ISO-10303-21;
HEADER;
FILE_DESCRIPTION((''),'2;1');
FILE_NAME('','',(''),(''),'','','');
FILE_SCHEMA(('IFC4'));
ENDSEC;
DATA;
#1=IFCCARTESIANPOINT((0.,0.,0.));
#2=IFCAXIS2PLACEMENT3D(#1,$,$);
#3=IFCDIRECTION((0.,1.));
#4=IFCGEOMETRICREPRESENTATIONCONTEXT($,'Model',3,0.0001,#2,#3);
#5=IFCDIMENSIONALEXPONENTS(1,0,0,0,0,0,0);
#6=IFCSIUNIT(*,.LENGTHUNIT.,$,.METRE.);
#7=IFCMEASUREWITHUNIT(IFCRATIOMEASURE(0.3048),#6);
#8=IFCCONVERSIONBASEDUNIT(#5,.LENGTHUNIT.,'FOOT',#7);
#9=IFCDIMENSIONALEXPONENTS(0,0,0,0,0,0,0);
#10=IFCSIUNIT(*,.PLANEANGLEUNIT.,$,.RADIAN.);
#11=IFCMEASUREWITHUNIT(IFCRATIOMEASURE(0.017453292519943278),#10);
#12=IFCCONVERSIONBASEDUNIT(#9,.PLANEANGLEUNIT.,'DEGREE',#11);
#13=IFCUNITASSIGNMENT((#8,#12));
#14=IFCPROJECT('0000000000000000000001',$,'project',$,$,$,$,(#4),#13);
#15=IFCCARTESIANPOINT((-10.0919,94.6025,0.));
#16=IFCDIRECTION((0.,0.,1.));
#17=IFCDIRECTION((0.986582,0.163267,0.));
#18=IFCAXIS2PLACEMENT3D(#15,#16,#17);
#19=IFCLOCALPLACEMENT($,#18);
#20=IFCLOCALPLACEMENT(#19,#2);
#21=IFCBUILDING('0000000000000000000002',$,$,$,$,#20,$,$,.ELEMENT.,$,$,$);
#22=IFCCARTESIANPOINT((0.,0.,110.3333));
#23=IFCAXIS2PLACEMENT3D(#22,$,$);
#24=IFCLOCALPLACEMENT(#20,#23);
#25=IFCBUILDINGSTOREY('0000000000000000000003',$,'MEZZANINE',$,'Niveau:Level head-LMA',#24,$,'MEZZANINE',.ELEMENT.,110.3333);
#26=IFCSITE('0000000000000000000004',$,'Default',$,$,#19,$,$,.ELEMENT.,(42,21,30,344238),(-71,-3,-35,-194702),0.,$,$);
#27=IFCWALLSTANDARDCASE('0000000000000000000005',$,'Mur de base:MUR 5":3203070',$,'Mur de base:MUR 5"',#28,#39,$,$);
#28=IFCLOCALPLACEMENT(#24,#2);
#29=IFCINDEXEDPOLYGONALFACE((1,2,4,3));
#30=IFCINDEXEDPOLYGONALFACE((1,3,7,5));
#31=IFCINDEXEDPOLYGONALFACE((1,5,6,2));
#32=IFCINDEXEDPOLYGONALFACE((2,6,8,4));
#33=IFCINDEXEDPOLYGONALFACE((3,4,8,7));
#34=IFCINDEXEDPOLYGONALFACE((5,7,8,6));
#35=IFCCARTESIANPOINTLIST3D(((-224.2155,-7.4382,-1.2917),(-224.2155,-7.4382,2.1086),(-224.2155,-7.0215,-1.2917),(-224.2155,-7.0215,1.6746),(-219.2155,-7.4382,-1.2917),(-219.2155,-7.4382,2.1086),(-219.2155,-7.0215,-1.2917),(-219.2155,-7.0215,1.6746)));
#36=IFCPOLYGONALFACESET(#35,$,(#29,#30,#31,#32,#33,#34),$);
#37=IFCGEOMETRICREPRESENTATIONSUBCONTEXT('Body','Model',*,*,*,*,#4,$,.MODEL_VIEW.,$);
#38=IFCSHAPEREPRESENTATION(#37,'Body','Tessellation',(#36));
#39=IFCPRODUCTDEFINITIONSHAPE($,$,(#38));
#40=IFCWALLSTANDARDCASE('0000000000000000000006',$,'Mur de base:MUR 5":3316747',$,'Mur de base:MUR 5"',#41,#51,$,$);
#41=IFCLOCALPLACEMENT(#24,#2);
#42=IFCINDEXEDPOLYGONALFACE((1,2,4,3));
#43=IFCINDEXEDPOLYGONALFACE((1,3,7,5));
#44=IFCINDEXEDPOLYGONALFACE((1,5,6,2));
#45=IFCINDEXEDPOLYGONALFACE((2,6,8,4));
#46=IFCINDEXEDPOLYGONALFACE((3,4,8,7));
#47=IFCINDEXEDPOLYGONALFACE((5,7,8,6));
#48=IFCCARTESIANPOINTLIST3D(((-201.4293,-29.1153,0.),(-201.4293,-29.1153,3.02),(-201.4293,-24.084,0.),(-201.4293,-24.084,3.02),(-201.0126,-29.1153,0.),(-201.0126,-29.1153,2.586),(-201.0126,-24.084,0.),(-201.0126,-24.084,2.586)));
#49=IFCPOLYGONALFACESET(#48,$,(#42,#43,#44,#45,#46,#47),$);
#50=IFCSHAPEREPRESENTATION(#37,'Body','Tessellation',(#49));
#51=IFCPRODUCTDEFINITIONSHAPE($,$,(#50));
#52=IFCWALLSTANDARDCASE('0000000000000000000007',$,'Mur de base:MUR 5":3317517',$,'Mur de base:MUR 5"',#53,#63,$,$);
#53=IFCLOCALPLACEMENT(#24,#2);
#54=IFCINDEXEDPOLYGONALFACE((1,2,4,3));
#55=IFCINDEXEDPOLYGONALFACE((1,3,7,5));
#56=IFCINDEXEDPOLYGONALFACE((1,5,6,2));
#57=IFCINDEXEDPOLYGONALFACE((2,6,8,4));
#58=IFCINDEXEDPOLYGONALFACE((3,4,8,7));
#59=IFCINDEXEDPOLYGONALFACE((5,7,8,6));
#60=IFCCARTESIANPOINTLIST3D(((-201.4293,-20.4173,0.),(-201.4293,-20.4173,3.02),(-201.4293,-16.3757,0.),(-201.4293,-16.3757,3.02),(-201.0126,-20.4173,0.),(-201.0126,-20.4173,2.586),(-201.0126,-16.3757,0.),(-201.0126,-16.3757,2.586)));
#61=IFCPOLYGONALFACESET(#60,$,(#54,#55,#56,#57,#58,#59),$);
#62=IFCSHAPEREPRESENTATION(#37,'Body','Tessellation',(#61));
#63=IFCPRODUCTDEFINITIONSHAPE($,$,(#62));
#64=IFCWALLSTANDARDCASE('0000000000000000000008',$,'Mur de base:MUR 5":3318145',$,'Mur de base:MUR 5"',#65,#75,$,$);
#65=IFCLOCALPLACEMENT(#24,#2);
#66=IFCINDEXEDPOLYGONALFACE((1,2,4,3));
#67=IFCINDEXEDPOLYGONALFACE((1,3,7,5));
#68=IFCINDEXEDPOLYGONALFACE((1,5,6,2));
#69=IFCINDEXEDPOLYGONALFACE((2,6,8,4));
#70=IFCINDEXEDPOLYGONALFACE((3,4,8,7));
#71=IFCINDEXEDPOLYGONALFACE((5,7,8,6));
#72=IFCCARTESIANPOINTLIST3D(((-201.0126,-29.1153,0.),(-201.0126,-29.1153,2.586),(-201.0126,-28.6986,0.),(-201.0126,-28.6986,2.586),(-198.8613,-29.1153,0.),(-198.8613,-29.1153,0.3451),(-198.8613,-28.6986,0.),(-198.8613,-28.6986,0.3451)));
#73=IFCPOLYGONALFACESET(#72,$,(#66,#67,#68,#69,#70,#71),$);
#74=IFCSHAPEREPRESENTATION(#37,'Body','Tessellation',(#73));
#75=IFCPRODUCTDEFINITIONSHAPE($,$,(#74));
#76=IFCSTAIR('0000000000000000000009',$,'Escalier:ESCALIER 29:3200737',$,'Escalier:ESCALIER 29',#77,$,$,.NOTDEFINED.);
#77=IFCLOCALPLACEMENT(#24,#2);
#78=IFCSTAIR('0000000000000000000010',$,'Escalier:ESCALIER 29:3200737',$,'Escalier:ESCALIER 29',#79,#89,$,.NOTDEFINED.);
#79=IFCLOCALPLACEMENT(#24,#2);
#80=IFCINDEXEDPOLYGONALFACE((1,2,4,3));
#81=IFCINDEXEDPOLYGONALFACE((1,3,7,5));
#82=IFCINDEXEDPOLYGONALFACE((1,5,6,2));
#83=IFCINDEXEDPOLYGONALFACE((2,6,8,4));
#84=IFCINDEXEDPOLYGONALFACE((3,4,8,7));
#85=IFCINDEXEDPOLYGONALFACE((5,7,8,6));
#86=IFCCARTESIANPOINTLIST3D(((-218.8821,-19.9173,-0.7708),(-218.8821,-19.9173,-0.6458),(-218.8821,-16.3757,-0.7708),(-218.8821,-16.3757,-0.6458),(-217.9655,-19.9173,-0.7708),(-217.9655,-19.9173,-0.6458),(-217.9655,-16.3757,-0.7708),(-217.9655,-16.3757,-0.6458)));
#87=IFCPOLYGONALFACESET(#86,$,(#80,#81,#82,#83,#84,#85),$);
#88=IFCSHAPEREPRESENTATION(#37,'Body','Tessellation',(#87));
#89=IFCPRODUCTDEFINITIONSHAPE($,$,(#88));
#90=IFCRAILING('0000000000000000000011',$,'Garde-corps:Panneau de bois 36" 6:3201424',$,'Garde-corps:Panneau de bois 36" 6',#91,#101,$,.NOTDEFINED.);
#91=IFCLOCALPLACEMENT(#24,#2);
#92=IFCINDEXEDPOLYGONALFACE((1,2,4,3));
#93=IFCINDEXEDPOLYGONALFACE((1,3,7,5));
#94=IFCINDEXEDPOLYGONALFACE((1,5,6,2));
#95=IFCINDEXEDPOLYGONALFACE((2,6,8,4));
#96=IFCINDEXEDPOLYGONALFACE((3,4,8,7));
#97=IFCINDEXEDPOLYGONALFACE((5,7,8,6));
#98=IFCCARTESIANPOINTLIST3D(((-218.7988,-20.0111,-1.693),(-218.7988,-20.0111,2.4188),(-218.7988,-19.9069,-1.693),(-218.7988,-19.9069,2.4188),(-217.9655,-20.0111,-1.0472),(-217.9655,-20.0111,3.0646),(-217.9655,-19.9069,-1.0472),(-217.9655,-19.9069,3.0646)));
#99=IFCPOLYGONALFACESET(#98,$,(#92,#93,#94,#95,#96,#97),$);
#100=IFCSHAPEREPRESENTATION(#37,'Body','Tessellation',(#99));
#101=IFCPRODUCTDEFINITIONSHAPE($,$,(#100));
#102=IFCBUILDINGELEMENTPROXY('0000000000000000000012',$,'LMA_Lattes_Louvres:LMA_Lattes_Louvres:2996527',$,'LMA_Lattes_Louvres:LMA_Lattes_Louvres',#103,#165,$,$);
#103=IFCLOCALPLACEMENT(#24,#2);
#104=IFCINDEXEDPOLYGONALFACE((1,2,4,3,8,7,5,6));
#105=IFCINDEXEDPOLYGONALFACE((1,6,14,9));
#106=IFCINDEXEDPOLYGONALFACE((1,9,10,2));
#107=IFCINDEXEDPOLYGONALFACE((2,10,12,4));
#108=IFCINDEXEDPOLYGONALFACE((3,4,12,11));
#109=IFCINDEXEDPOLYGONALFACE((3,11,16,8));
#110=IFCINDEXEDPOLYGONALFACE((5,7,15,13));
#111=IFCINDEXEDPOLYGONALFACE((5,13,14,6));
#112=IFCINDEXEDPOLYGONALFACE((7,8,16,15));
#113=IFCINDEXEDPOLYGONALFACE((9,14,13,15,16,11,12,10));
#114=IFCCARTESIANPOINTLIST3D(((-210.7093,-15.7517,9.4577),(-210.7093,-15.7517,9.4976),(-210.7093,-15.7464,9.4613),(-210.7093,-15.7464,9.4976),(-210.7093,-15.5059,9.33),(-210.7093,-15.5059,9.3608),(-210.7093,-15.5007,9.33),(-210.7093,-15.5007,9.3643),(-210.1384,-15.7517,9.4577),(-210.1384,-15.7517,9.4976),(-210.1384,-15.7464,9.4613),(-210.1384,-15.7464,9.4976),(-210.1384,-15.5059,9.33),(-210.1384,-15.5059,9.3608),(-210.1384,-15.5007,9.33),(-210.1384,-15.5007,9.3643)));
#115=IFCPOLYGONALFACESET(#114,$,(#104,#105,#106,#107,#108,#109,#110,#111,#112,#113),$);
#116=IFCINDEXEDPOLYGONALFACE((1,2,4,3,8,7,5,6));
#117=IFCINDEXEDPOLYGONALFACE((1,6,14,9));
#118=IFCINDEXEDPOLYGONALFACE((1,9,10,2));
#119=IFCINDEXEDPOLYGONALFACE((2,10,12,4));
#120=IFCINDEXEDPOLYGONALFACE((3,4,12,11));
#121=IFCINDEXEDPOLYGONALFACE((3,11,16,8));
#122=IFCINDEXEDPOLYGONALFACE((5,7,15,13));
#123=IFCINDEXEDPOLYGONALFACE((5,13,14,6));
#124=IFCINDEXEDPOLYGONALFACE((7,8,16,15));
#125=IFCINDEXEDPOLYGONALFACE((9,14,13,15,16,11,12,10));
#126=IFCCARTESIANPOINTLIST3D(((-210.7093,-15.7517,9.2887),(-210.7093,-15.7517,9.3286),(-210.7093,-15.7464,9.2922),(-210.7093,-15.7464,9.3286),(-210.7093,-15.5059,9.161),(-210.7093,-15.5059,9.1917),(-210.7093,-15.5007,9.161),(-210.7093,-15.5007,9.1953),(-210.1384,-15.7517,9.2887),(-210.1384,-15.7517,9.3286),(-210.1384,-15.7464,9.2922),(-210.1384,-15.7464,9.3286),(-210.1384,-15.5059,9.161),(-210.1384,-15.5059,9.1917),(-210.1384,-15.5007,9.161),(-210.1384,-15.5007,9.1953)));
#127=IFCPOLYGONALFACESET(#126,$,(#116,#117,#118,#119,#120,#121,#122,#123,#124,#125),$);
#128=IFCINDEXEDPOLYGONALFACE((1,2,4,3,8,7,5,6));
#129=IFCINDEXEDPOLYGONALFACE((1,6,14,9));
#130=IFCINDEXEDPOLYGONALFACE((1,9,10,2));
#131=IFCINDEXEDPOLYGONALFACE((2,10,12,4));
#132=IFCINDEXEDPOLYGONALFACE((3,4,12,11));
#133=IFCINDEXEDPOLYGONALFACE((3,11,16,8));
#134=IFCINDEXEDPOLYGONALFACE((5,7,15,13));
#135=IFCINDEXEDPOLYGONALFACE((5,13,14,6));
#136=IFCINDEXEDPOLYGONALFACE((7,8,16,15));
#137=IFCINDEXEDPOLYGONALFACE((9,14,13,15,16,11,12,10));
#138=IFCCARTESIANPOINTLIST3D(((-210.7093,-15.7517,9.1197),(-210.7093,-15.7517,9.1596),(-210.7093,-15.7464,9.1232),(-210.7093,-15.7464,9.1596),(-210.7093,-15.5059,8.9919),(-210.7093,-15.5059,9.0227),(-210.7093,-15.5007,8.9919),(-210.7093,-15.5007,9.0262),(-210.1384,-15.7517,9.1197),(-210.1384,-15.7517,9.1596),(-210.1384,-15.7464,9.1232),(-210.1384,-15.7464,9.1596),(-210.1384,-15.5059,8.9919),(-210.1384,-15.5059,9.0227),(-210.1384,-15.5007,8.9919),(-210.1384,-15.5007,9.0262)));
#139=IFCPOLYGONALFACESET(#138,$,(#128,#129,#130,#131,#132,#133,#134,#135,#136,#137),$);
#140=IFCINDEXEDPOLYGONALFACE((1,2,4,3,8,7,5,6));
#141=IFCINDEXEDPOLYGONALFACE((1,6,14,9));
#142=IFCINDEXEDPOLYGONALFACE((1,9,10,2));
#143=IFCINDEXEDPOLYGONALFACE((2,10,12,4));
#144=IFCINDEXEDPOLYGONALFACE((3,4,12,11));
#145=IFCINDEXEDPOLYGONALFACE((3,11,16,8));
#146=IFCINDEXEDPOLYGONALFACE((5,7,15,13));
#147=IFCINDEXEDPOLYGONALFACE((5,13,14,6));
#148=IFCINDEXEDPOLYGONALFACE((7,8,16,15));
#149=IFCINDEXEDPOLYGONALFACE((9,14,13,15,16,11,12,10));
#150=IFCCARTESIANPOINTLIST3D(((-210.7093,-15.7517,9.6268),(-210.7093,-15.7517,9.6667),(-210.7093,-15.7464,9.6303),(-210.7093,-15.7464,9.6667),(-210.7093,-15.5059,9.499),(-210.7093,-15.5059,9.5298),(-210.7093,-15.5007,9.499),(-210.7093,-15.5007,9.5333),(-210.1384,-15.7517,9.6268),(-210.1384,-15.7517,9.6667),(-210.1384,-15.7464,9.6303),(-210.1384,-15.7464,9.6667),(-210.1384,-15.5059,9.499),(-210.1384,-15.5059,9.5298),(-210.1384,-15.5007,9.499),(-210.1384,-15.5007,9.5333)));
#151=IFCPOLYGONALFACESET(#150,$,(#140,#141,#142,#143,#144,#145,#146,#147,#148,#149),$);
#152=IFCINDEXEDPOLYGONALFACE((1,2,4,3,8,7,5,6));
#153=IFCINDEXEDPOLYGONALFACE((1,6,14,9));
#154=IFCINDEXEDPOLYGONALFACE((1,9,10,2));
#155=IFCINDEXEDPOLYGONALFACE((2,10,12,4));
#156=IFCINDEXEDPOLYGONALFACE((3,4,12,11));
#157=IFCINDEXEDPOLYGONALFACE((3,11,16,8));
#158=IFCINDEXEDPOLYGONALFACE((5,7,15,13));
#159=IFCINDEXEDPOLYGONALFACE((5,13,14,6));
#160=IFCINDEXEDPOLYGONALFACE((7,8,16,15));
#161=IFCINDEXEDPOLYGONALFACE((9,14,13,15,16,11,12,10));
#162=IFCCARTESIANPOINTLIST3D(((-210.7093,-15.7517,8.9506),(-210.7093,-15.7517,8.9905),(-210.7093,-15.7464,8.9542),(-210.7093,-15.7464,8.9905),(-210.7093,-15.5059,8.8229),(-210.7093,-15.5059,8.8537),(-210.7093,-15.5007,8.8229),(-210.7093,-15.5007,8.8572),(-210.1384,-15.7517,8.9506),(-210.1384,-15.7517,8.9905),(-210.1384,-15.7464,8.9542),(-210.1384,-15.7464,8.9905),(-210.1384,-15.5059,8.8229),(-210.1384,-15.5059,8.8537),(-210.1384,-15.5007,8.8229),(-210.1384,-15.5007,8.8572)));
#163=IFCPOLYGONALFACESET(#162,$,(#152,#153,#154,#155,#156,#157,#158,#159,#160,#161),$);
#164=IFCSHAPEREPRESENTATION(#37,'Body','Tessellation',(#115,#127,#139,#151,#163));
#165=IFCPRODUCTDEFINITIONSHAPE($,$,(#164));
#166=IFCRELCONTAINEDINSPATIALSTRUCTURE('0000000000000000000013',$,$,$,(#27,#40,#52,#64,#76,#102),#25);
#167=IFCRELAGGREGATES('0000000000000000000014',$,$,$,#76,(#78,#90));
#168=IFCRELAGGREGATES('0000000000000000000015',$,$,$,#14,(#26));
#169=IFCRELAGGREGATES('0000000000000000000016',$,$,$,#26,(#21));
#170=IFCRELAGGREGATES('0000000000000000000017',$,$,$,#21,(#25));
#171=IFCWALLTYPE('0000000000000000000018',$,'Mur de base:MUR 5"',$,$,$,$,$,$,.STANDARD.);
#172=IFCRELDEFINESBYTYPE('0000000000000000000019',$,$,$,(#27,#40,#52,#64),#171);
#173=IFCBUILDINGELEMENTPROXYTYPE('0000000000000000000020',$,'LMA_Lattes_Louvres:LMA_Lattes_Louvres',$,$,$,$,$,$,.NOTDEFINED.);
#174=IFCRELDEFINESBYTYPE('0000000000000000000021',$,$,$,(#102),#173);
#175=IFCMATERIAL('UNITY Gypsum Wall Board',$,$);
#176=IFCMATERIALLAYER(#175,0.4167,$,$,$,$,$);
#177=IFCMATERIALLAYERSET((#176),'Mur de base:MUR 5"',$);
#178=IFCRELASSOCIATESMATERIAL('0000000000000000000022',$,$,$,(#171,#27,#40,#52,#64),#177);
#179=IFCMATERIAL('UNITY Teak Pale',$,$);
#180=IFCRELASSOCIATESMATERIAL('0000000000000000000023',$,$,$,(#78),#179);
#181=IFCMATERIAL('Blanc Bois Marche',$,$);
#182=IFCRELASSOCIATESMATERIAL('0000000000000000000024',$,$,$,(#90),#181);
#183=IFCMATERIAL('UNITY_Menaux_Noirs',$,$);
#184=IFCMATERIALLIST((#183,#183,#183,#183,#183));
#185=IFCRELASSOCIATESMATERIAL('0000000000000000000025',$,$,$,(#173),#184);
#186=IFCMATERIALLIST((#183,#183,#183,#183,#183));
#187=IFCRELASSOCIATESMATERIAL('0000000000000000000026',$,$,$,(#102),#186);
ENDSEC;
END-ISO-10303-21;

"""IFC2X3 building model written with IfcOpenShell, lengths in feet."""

from ifc_helpers import new_model, entity, si_unit, converted_unit, direction, frame, frame_2d, origin, place, context, subcontext, project, spatial, polyline, rectangle, outline, extrude, clip, bounded_halfspace, source, transform, mapped, material, material_list, layer, layer_set, layer_usage, type_object, type_shapes, element, aggregate, save


model = new_model("IFC2X3")

# Units and contexts
model_context = context("Model", 3, precision=0.0001, world=origin(), true_north=direction((0.0, 1.0)))
body_context = subcontext(model_context, "Body", "Model", "MODEL_VIEW")
ifc_project = project(units=[converted_unit("LENGTHUNIT", "FOOT", entity("IfcRatioMeasure", 0.3048), si_unit("LENGTHUNIT", "METRE"), dimensions=[1, 0, 0, 0, 0, 0, 0]), converted_unit("PLANEANGLEUNIT", "DEGREE", entity("IfcRatioMeasure", 0.017453292519943278), si_unit("PLANEANGLEUNIT", "RADIAN"), dimensions=[0, 0, 0, 0, 0, 0, 0])], contexts=[model_context])

# Site, building, storey
site_placement = place(None, frame((-10.0919, 94.6025, 0.0), z_axis=(0.0, 0.0, 1.0), x_axis=(0.986582, 0.163267, 0.0)))
site = spatial("IfcSite", under=ifc_project, at=site_placement, Name="Default", CompositionType="ELEMENT", RefLatitude=(42, 21, 30, 344238), RefLongitude=(-71, -3, -35, -194702), RefElevation=0.0)
building_placement = place(site_placement, origin())
building = spatial("IfcBuilding", under=site, at=building_placement, CompositionType="ELEMENT")
storey_placement = place(building_placement, frame((0.0, 0.0, 110.3333)))
storey = spatial("IfcBuildingStorey", under=building, at=storey_placement, Name="MEZZANINE", ObjectType="Niveau:Level head-LMA", LongName="MEZZANINE", CompositionType="ELEMENT", Elevation=110.3333)

# Shared definitions
ifc_material_1 = material(Name="UNITY Gypsum Wall Board")
ifc_layer_1 = layer(ifc_material_1, 0.4167)
ifc_layer_set_1 = layer_set([ifc_layer_1], Name="Mur de base:MUR 5\"")
wall_type_1 = type_object("IfcWallType", Name="Mur de base:MUR 5\"", PredefinedType="STANDARD", material=ifc_layer_set_1)

# Walls
ifc_layer_usage_1 = layer_usage(ifc_layer_set_1, "AXIS2", "POSITIVE", -0.2083)
wall_1_placement = place(storey_placement, frame((-224.2155, -7.2298, -1.2917)))
element("IfcWallStandardCase", 1, at=wall_1_placement, inside=storey, type_object=wall_type_1, material=ifc_layer_usage_1, Name="Mur de base:MUR 5\":3203070", ObjectType="Mur de base:MUR 5\"", context=body_context, shape_type="Clipping", body=[
    clip(extrude(rectangle(XDim=5.0, YDim=0.4167, at=frame_2d((2.5, 0.0), x_axis=(-1.0, 0.0))), origin(), (0.0, 0.0, 1.0), 3.4003), bounded_halfspace(frame((0.0, -0.2083, 3.4003), z_axis=(0.0, 0.721387, 0.692532), x_axis=(-1.0, 0.0, 0.0)), False, frame((0.0, -0.2083, 3.4003)), polyline([(0.0, 0.0), (5.0, 0.0), (5.0, 0.4167), (0.0, 0.4167), (0.0, 0.0)]))),
])
ifc_layer_usage_2 = layer_usage(ifc_layer_set_1, "AXIS2", "NEGATIVE", 0.2083)
wall_2_placement = place(storey_placement, frame((-201.2209, -29.1153, 0.0), z_axis=(0.0, 0.0, 1.0), x_axis=(0.0, 1.0, 0.0)))
element("IfcWallStandardCase", 2, at=wall_2_placement, inside=storey, type_object=wall_type_1, material=ifc_layer_usage_2, Name="Mur de base:MUR 5\":3316747", ObjectType="Mur de base:MUR 5\"", context=body_context, shape_type="Clipping", body=[
    clip(extrude(rectangle(XDim=5.0312, YDim=0.4167, at=frame_2d((2.5156, 0.0), x_axis=(-1.0, 0.0))), origin(), (0.0, 0.0, 1.0), 3.02), bounded_halfspace(frame((0.0, -0.2083, 2.586), z_axis=(0.0, -0.721387, 0.692532), x_axis=(1.0, 0.0, 0.0)), False, frame((0.0, -0.2083, 2.586)), polyline([(0.0, 0.0), (0.4167, 0.0), (5.0312, 0.0), (5.0312, 0.4167), (0.0, 0.4167), (0.0, 0.0)]))),
])
ifc_layer_usage_3 = layer_usage(ifc_layer_set_1, "AXIS2", "NEGATIVE", 0.2083)
wall_3_placement = place(storey_placement, frame((-201.2209, -20.4173, 0.0), z_axis=(0.0, 0.0, 1.0), x_axis=(0.0, 1.0, 0.0)))
element("IfcWallStandardCase", 3, at=wall_3_placement, inside=storey, type_object=wall_type_1, material=ifc_layer_usage_3, Name="Mur de base:MUR 5\":3317517", ObjectType="Mur de base:MUR 5\"", context=body_context, shape_type="Clipping", body=[
    clip(extrude(rectangle(XDim=4.0417, YDim=0.4167, at=frame_2d((2.0208, 0.0), x_axis=(-1.0, 0.0))), origin(), (0.0, 0.0, 1.0), 3.02), bounded_halfspace(frame((0.0, -0.2083, 2.586), z_axis=(0.0, -0.721387, 0.692532), x_axis=(1.0, 0.0, 0.0)), False, frame((0.0, -0.2083, 2.586)), polyline([(0.0, 0.0), (4.0417, 0.0), (4.0417, 0.4167), (0.0, 0.4167), (0.0, 0.0)]))),
])

# Wall
ifc_layer_usage_4 = layer_usage(ifc_layer_set_1, "AXIS2", "NEGATIVE", 0.2083)
wall_4_placement = place(storey_placement, frame((-198.8613, -28.9069, 0.0), z_axis=(0.0, 0.0, 1.0), x_axis=(-1.0, 0.0, 0.0)))
element("IfcWallStandardCase", 4, at=wall_4_placement, inside=storey, type_object=wall_type_1, material=ifc_layer_usage_4, Name="Mur de base:MUR 5\":3318145", ObjectType="Mur de base:MUR 5\"", context=body_context, shape_type="Clipping", body=[
    clip(extrude(rectangle(XDim=2.1513, YDim=0.4167, at=frame_2d((1.0756, 0.0), x_axis=(-1.0, 0.0))), origin(), (0.0, 0.0, 1.0), 2.586), bounded_halfspace(frame((0.0, -0.2083, 0.3451), z_axis=(-0.721387, 0.0, 0.692532), x_axis=(0.0, -1.0, 0.0)), False, frame((0.0, -0.2083, 0.3451)), polyline([(0.0, 0.0), (2.1513, 0.0), (2.1513, 0.4167), (0.0, 0.4167), (0.0, 0.0)]))),
])

# Stairs
stair_1_placement = place(storey_placement, origin())
stair_1 = element("IfcStair", 5, at=stair_1_placement, inside=storey, Name="Escalier:ESCALIER 29:3200737", ObjectType="Escalier:ESCALIER 29", ShapeType="NOTDEFINED")
ifc_material_2 = material(Name="UNITY Teak Pale")
stair_2_placement = place(stair_1_placement, origin())
stair_2 = element("IfcStair", 6, at=stair_2_placement, material=ifc_material_2, Name="Escalier:ESCALIER 29:3200737", ObjectType="Escalier:ESCALIER 29", ShapeType="NOTDEFINED", context=body_context, shape_type="SweptSolid", body=[
    extrude(rectangle(XDim=0.9167, YDim=3.5417, at=frame_2d((0.0, 0.0), x_axis=(1.0, 0.0))), frame((-218.4238, -18.1465, -0.7708), z_axis=(0.0, 0.0, 1.0), x_axis=(-1.0, 0.0, 0.0)), (0.0, 0.0, 1.0), 0.125),
])

# Railing
ifc_material_3 = material(Name="Blanc Bois Marche")
railing_1_placement = place(stair_1_placement, frame((0.0, 0.0, -1.0)))
railing_1 = element("IfcRailing", 7, at=railing_1_placement, material=ifc_material_3, Name="Garde-corps:Panneau de bois 36\" 6:3201424", ObjectType="Garde-corps:Panneau de bois 36\" 6", PredefinedType="NOTDEFINED", context=body_context, shape_type="SweptSolid", body=[
    extrude(outline(polyline([(0.7322, -1.625), (1.7865, -1.625), (-0.7322, 1.625), (-1.7865, 1.625), (0.7322, -1.625)])), frame((-218.3821, -20.0111, 1.6858), z_axis=(0.0, 1.0, 0.0), x_axis=(0.790415, 0.0, 0.612572)), (0.0, 0.0, 1.0), 0.1042),
])
aggregate(stair_1, [stair_2, railing_1])

# Building element proxy
ifc_material_4 = material(Name="UNITY_Menaux_Noirs")
ifc_material_list_1 = material_list([ifc_material_4, ifc_material_4, ifc_material_4, ifc_material_4, ifc_material_4])
ifc_material_list_2 = material_list([ifc_material_4, ifc_material_4, ifc_material_4, ifc_material_4, ifc_material_4])
building_element_proxy_type = type_object("IfcBuildingElementProxyType", Name="LMA_Lattes_Louvres:LMA_Lattes_Louvres", PredefinedType="NOTDEFINED", material=ifc_material_list_2)
shared_shape_1 = source(origin(), body_context, "Body", "SweptSolid", [
    extrude(outline(polyline([(-0.1298, -0.0013), (0.1344, -0.0013), (0.147, 0.0306), (0.1421, 0.0325), (0.1308, 0.0039), (-0.1334, 0.0039), (-0.148, -0.0332), (-0.1432, -0.0351), (-0.1298, -0.0013)])), frame((-0.2854, -0.1255, 0.5895), z_axis=(1.0, 0.0, 0.0), x_axis=(0.0, -0.930221, -0.367)), (0.0, 0.0, 1.0), 0.5709),
    extrude(outline(polyline([(-0.1298, -0.0013), (0.1344, -0.0013), (0.147, 0.0306), (0.1421, 0.0325), (0.1308, 0.0039), (-0.1334, 0.0039), (-0.148, -0.0332), (-0.1432, -0.0351), (-0.1298, -0.0013)])), frame((-0.2854, -0.1255, 0.4205), z_axis=(1.0, 0.0, 0.0), x_axis=(0.0, -0.930221, -0.367)), (0.0, 0.0, 1.0), 0.5709),
    extrude(outline(polyline([(-0.1298, -0.0013), (0.1344, -0.0013), (0.147, 0.0306), (0.1421, 0.0325), (0.1308, 0.0039), (-0.1334, 0.0039), (-0.148, -0.0332), (-0.1432, -0.0351), (-0.1298, -0.0013)])), frame((-0.2854, -0.1255, 0.2514), z_axis=(1.0, 0.0, 0.0), x_axis=(0.0, -0.930221, -0.367)), (0.0, 0.0, 1.0), 0.5709),
    extrude(outline(polyline([(-0.1298, -0.0013), (0.1344, -0.0013), (0.147, 0.0306), (0.1421, 0.0325), (0.1308, 0.0039), (-0.1334, 0.0039), (-0.148, -0.0332), (-0.1432, -0.0351), (-0.1298, -0.0013)])), frame((-0.2854, -0.1255, 0.7585), z_axis=(1.0, 0.0, 0.0), x_axis=(0.0, -0.930221, -0.367)), (0.0, 0.0, 1.0), 0.5709),
    extrude(outline(polyline([(-0.1298, -0.0013), (0.1344, -0.0013), (0.147, 0.0306), (0.1421, 0.0325), (0.1308, 0.0039), (-0.1334, 0.0039), (-0.148, -0.0332), (-0.1432, -0.0351), (-0.1298, -0.0013)])), frame((-0.2854, -0.1255, 0.0824), z_axis=(1.0, 0.0, 0.0), x_axis=(0.0, -0.930221, -0.367)), (0.0, 0.0, 1.0), 0.5709),
])
type_shapes(building_element_proxy_type, [shared_shape_1])
proxy_placement = place(storey_placement, frame((-210.4238, -15.7517, 8.8229), z_axis=(0.0, 0.0, 1.0), x_axis=(-1.0, 0.0, 0.0)))
element("IfcBuildingElementProxy", 8, at=proxy_placement, inside=storey, type_object=building_element_proxy_type, material=ifc_material_list_1, Name="LMA_Lattes_Louvres:LMA_Lattes_Louvres:2996527", ObjectType="LMA_Lattes_Louvres:LMA_Lattes_Louvres", context=body_context, shape_type="MappedRepresentation", body=[
    mapped(shared_shape_1, transform((0.0, 0.0, 0.0), scale=1.0)),
])

save(model, "model.ifc")
